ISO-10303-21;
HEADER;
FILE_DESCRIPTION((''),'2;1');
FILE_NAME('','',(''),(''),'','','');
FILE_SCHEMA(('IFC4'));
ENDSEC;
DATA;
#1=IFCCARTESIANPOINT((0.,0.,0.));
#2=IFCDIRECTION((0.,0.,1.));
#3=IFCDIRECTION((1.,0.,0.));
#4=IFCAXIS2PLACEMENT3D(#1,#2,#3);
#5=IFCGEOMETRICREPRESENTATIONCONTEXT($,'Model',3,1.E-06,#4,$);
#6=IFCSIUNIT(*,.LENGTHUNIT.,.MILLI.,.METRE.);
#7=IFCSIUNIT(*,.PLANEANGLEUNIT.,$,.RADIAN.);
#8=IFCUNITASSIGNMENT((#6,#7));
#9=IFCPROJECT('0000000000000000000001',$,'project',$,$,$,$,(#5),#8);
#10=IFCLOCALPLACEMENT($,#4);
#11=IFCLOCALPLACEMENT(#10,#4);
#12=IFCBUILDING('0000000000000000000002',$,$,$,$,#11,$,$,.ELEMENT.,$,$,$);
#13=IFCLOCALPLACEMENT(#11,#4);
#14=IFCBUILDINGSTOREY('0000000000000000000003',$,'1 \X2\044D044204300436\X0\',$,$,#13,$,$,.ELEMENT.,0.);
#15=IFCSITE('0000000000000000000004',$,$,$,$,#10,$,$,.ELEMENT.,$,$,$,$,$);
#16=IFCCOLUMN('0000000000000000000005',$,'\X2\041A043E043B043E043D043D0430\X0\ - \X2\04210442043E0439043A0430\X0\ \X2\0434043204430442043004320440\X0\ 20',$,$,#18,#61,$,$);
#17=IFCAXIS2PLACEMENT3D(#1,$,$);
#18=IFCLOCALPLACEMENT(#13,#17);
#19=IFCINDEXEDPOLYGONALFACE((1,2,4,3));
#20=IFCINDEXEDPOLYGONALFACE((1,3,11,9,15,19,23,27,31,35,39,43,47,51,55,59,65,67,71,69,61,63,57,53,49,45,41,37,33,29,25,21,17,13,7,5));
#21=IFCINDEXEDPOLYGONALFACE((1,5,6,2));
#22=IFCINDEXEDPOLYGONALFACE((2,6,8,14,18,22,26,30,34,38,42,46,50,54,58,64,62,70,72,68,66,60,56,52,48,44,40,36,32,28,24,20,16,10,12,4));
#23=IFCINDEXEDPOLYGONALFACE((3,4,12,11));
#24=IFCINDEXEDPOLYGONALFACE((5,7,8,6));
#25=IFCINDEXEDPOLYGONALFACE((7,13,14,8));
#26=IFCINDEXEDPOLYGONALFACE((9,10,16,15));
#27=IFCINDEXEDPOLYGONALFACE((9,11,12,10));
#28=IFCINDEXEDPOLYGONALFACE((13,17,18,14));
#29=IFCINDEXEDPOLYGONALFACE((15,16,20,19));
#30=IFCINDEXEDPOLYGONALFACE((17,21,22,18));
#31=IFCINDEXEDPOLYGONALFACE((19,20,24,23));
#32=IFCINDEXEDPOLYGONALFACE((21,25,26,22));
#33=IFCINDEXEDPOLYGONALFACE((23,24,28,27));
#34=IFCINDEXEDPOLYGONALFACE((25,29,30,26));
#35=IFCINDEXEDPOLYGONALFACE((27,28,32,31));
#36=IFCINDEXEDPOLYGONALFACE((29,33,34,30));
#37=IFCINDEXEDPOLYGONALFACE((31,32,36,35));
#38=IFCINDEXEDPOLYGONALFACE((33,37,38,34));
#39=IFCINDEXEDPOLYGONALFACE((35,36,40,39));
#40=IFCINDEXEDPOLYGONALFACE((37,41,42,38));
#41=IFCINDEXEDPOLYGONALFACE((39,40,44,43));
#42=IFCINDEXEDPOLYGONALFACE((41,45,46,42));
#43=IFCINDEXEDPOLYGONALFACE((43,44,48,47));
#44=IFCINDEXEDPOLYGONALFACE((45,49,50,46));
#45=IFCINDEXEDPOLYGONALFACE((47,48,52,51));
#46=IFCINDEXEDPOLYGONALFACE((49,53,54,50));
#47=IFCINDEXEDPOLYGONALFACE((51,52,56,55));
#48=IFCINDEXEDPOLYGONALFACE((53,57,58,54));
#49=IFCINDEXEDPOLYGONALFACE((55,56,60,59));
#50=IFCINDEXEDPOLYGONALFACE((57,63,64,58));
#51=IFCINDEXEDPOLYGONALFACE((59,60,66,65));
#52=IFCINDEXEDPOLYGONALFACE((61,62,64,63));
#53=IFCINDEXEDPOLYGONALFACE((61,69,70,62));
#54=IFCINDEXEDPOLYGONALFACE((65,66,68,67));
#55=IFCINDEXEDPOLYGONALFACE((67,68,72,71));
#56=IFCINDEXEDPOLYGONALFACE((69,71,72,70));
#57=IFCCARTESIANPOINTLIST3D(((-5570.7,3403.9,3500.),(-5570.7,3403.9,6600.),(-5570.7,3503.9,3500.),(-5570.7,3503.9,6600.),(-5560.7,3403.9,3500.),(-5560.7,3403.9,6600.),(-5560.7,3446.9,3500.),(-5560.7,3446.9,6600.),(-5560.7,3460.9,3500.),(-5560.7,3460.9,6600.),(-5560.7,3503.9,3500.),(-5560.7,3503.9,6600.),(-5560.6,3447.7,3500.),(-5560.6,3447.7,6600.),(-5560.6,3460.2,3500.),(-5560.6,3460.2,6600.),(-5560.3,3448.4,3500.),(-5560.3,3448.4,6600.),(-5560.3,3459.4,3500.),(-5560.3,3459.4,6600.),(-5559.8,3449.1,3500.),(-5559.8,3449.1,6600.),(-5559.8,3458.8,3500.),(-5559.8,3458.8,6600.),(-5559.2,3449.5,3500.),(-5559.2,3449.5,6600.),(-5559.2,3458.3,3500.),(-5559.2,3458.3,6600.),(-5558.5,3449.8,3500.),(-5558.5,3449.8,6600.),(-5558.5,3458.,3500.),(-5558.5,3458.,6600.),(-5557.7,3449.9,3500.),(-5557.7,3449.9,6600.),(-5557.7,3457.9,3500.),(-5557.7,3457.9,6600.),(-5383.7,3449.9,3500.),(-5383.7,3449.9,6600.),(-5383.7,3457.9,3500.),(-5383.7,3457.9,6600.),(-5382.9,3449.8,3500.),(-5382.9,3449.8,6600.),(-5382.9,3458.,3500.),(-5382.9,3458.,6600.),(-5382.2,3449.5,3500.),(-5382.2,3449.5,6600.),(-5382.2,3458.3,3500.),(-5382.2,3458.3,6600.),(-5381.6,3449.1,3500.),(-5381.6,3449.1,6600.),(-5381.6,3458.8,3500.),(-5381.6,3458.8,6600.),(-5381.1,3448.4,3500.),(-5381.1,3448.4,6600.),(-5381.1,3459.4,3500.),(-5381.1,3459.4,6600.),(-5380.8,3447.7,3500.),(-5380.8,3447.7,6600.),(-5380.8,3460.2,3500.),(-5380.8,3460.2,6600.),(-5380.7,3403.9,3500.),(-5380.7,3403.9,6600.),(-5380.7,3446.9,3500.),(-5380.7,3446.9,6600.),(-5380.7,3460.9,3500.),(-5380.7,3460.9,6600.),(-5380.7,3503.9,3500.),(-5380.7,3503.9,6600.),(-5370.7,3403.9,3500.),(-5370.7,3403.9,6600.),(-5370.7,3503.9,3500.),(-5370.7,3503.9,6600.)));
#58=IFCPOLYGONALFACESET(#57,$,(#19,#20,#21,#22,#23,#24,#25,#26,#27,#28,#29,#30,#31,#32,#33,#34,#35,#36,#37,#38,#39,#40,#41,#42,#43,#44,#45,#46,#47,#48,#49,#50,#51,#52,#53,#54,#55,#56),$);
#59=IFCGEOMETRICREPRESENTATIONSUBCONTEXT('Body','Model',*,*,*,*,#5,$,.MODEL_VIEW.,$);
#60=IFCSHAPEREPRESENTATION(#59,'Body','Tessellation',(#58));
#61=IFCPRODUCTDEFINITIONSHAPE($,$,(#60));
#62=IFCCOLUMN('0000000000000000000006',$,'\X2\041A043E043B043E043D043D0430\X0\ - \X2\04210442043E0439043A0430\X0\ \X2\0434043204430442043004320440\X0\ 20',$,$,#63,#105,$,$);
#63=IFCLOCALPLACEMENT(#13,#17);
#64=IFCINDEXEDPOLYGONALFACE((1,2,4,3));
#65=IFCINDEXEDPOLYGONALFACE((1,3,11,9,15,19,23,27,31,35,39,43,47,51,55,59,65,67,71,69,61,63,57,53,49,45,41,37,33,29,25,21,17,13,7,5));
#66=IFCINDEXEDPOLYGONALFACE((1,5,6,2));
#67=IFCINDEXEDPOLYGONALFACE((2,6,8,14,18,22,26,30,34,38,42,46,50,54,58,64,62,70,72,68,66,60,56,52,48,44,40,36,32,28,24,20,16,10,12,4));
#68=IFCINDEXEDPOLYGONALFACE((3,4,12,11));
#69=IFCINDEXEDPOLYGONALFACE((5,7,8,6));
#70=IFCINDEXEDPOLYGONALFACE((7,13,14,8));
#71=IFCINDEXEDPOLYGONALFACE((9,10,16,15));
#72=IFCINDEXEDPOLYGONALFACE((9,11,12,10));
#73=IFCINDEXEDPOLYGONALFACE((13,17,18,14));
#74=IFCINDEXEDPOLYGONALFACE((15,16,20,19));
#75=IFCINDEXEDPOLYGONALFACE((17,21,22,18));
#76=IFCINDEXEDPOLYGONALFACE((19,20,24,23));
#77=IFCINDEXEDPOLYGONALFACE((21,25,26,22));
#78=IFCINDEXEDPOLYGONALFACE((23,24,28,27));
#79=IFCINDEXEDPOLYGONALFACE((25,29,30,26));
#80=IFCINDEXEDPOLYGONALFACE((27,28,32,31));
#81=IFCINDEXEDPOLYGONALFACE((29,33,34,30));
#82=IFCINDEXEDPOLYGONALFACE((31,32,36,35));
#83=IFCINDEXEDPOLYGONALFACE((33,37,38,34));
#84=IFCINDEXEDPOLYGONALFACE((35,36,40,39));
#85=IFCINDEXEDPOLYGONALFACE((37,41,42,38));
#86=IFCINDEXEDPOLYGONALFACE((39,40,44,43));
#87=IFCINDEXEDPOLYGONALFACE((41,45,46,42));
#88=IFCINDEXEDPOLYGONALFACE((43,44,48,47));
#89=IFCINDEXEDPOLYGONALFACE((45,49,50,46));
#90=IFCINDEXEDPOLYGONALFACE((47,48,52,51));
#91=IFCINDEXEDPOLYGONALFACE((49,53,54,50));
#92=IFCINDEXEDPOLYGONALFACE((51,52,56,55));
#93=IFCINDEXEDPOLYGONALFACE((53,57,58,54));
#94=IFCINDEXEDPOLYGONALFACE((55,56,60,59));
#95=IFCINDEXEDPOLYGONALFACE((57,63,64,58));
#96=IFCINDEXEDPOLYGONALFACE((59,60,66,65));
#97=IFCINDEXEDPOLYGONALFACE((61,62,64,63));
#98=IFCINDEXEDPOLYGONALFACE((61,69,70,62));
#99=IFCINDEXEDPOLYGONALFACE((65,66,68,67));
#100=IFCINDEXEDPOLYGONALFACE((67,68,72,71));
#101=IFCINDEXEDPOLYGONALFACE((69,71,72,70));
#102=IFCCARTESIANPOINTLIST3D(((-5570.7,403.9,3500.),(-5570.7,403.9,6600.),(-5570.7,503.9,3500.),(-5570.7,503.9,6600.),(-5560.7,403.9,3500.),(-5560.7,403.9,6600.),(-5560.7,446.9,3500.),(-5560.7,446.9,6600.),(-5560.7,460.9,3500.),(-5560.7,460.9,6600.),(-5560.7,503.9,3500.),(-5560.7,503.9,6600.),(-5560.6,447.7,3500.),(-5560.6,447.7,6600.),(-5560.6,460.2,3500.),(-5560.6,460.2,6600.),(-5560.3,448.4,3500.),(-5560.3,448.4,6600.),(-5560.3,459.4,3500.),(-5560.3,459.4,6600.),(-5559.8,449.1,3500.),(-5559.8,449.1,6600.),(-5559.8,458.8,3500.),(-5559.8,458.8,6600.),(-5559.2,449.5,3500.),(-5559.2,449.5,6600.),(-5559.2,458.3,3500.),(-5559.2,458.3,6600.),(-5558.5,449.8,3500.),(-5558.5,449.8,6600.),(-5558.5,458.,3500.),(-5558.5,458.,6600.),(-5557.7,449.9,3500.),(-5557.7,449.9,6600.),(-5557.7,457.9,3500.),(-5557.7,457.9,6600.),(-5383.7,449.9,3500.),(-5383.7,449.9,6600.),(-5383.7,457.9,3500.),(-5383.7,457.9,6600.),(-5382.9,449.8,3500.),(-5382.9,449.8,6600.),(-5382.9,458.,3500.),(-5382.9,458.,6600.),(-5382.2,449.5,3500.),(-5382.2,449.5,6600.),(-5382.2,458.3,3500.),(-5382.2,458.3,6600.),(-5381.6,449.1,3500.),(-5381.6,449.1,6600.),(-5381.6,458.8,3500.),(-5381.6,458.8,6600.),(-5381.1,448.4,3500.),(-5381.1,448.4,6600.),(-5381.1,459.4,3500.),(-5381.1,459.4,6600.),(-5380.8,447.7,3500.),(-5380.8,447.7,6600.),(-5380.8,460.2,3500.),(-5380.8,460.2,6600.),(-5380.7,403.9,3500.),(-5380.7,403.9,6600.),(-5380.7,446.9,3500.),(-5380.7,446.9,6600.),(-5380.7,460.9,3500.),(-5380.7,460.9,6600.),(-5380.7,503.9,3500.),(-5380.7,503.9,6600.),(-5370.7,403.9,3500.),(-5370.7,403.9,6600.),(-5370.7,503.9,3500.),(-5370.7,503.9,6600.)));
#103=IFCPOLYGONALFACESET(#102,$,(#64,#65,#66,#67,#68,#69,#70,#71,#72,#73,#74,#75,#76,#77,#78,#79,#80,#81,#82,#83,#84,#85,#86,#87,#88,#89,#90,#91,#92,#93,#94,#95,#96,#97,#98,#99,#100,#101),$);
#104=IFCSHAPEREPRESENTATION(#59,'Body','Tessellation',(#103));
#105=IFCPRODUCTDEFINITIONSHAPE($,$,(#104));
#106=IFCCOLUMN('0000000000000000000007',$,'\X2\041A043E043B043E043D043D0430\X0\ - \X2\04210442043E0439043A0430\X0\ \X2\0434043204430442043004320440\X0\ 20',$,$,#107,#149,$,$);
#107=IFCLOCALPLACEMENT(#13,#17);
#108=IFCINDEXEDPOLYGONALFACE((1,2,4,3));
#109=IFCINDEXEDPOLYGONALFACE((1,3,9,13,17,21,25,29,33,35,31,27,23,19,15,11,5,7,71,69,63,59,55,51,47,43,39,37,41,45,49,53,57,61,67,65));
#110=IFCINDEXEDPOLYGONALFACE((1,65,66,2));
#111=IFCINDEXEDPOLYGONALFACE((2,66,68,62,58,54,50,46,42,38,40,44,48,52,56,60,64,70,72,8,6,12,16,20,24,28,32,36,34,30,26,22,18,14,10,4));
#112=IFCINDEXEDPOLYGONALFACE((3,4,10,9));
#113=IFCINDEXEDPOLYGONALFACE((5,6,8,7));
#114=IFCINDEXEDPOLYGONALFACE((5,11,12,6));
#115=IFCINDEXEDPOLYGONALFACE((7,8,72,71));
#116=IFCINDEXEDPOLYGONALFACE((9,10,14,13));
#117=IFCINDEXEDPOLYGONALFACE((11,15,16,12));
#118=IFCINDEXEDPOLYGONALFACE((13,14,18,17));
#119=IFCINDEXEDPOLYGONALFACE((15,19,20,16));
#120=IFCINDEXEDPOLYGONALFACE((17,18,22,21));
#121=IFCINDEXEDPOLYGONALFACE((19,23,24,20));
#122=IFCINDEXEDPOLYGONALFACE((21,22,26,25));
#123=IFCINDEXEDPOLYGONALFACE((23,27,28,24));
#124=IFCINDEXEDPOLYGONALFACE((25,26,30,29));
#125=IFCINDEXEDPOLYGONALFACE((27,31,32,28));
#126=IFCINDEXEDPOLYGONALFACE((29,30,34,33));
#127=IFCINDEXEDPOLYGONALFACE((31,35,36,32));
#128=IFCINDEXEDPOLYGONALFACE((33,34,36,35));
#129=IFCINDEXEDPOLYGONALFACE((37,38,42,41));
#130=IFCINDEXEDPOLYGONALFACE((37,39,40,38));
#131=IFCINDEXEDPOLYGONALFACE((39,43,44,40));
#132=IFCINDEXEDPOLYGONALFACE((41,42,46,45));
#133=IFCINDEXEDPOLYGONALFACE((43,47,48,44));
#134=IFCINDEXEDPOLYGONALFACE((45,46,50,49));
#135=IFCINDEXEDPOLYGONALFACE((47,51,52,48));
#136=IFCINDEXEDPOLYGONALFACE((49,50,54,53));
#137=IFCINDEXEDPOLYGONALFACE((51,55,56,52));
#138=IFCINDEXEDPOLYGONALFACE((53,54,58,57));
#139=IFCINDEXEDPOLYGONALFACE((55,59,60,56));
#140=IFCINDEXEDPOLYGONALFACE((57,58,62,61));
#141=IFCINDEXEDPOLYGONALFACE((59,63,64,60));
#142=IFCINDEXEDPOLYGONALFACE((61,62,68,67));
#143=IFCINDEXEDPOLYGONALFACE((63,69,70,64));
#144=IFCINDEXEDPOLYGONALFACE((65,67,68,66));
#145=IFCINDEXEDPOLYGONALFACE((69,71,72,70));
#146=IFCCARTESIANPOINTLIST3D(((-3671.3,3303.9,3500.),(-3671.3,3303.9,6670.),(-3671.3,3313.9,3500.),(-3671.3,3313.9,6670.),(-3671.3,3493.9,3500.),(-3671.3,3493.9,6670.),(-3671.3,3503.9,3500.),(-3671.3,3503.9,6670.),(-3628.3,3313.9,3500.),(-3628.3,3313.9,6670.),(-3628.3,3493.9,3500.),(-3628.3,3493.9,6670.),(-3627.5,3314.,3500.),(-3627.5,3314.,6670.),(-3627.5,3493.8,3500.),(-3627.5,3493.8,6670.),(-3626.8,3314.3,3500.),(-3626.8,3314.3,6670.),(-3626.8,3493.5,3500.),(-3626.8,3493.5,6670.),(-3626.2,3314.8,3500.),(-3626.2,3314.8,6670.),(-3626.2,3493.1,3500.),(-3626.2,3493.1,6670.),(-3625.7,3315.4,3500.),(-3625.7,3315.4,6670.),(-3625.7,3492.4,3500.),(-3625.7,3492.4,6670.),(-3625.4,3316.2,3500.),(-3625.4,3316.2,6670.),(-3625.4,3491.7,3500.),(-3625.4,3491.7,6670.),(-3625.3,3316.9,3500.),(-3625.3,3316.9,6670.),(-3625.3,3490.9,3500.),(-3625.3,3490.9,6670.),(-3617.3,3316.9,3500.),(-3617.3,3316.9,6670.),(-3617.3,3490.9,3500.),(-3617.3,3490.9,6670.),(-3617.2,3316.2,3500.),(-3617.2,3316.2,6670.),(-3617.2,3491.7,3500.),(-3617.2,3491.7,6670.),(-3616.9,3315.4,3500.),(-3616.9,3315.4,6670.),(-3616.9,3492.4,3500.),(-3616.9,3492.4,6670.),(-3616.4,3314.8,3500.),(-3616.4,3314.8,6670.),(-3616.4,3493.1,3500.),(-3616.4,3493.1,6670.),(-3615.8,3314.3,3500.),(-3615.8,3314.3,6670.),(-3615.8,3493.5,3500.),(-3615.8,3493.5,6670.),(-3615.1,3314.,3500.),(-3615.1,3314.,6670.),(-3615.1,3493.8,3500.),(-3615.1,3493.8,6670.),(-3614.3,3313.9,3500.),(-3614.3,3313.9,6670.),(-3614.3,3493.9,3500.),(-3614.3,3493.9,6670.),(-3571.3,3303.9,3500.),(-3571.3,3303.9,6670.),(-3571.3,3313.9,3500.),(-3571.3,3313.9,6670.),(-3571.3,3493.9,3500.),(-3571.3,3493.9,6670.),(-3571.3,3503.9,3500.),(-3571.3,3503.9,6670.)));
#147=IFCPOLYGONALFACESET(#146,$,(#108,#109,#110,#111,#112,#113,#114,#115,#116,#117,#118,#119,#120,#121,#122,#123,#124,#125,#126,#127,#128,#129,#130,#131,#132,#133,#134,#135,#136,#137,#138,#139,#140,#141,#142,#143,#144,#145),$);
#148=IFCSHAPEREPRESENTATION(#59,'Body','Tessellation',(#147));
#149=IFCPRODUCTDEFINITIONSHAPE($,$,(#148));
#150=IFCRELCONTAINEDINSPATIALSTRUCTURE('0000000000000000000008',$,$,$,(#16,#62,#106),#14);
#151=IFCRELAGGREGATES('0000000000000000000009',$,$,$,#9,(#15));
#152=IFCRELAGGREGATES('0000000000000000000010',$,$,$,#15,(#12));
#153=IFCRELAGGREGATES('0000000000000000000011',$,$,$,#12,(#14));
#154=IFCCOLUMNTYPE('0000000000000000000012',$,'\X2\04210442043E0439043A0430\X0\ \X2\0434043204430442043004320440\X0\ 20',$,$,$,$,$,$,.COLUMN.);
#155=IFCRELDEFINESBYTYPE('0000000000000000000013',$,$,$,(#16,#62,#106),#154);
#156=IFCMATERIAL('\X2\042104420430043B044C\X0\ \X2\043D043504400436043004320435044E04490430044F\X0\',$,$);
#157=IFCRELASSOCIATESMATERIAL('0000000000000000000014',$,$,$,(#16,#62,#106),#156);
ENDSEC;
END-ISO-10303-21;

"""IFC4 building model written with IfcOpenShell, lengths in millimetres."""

from ifc_helpers import new_model, si_unit, frame, origin_with_axes, place, context, subcontext, project, spatial, line, arc, indexed_curve, outline, extrude, source, transform, mapped, material, type_object, element, save


model = new_model("IFC4")

# Units and contexts
model_context = context("Model", 3, precision=1e-06, world=origin_with_axes())
body_context = subcontext(model_context, "Body", "Model", "MODEL_VIEW")
ifc_project = project(units=[si_unit("LENGTHUNIT", "METRE", prefix="MILLI"), si_unit("PLANEANGLEUNIT", "RADIAN")], contexts=[model_context])

# Site, building, storey
site_placement = place(None, origin_with_axes())
site = spatial("IfcSite", under=ifc_project, at=site_placement, CompositionType="ELEMENT")
building_placement = place(site_placement, origin_with_axes())
building = spatial("IfcBuilding", under=site, at=building_placement, CompositionType="ELEMENT")
storey_placement = place(building_placement, origin_with_axes())
storey = spatial("IfcBuildingStorey", under=building, at=storey_placement, Name="1 этаж", CompositionType="ELEMENT", Elevation=0.0)

# Columns
ifc_material_1 = material(Name="Сталь нержавеющая")
column_type = type_object("IfcColumnType", Name="Стойка двутавр 20", PredefinedType="COLUMN")
shared_shape_1 = source(origin_with_axes(), body_context, "Body", "SweptSolid", [
    extrude(outline(indexed_curve([(-50.0, -100.0), (50.0, -100.0), (50.0, -90.0), (7.0, -90.0), (4.9, -89.1), (4.0, -87.0), (4.0, 87.0), (4.9, 89.1), (7.0, 90.0), (50.0, 90.0), (50.0, 100.0), (-50.0, 100.0), (-50.0, 90.0), (-7.0, 90.0), (-4.9, 89.1), (-4.0, 87.0), (-4.0, -87.0), (-4.9, -89.1), (-7.0, -90.0), (-50.0, -90.0)], segments=[line(1, 2), line(2, 3), line(3, 4), arc(4, 5, 6), line(6, 7), arc(7, 8, 9), line(9, 10), line(10, 11), line(11, 12), line(12, 13), line(13, 14), arc(14, 15, 16), line(16, 17), arc(17, 18, 19), line(19, 20), line(20, 1)])), origin_with_axes(), (0.0, 0.0, 1.0), 3100.0),
])
for number, where, z_axis, x_axis, name in (
    (1, (-5470.7, 3453.9, 3500.0), (0.0, 0.0, 1.0), (0.0, 1.0, 0.0), "Колонна - Стойка двутавр 20"),
    (2, (-5470.7, 453.9, 3500.0), (0.0, 0.0, 1.0), (0.0, 1.0, 0.0), "Колонна - Стойка двутавр 20"),
):
    element("IfcColumn", number, at=place(storey_placement, frame(where, z_axis=z_axis, x_axis=x_axis)), inside=storey, type_object=column_type, material=ifc_material_1, Name=name, context=body_context, shape_type="MappedRepresentation", body=[
        mapped(shared_shape_1, transform((0.0, 0.0, 0.0), x_axis=(1.0, 0.0, 0.0), y_axis=(0.0, 1.0, 0.0), z_axis=(0.0, 0.0, 1.0), scale=1.0)),
    ])
shared_shape_2 = source(origin_with_axes(), body_context, "Body", "SweptSolid", [
    extrude(outline(indexed_curve([(-50.0, -100.0), (50.0, -100.0), (50.0, -90.0), (7.0, -90.0), (4.9, -89.1), (4.0, -87.0), (4.0, 87.0), (4.9, 89.1), (7.0, 90.0), (50.0, 90.0), (50.0, 100.0), (-50.0, 100.0), (-50.0, 90.0), (-7.0, 90.0), (-4.9, 89.1), (-4.0, 87.0), (-4.0, -87.0), (-4.9, -89.1), (-7.0, -90.0), (-50.0, -90.0)], segments=[line(1, 2), line(2, 3), line(3, 4), arc(4, 5, 6), line(6, 7), arc(7, 8, 9), line(9, 10), line(10, 11), line(11, 12), line(12, 13), line(13, 14), arc(14, 15, 16), line(16, 17), arc(17, 18, 19), line(19, 20), line(20, 1)])), origin_with_axes(), (0.0, 0.0, 1.0), 3170.0),
])
column_1_placement = place(storey_placement, frame((-3621.3, 3403.9, 3500.0), z_axis=(0.0, 0.0, 1.0), x_axis=(1.0, 0.0, 0.0)))
element("IfcColumn", 3, at=column_1_placement, inside=storey, type_object=column_type, material=ifc_material_1, Name="Колонна - Стойка двутавр 20", context=body_context, shape_type="MappedRepresentation", body=[
    mapped(shared_shape_2, transform((0.0, 0.0, 0.0), x_axis=(1.0, 0.0, 0.0), y_axis=(0.0, 1.0, 0.0), z_axis=(0.0, 0.0, 1.0), scale=1.0)),
])

save(model, "model.ifc")
